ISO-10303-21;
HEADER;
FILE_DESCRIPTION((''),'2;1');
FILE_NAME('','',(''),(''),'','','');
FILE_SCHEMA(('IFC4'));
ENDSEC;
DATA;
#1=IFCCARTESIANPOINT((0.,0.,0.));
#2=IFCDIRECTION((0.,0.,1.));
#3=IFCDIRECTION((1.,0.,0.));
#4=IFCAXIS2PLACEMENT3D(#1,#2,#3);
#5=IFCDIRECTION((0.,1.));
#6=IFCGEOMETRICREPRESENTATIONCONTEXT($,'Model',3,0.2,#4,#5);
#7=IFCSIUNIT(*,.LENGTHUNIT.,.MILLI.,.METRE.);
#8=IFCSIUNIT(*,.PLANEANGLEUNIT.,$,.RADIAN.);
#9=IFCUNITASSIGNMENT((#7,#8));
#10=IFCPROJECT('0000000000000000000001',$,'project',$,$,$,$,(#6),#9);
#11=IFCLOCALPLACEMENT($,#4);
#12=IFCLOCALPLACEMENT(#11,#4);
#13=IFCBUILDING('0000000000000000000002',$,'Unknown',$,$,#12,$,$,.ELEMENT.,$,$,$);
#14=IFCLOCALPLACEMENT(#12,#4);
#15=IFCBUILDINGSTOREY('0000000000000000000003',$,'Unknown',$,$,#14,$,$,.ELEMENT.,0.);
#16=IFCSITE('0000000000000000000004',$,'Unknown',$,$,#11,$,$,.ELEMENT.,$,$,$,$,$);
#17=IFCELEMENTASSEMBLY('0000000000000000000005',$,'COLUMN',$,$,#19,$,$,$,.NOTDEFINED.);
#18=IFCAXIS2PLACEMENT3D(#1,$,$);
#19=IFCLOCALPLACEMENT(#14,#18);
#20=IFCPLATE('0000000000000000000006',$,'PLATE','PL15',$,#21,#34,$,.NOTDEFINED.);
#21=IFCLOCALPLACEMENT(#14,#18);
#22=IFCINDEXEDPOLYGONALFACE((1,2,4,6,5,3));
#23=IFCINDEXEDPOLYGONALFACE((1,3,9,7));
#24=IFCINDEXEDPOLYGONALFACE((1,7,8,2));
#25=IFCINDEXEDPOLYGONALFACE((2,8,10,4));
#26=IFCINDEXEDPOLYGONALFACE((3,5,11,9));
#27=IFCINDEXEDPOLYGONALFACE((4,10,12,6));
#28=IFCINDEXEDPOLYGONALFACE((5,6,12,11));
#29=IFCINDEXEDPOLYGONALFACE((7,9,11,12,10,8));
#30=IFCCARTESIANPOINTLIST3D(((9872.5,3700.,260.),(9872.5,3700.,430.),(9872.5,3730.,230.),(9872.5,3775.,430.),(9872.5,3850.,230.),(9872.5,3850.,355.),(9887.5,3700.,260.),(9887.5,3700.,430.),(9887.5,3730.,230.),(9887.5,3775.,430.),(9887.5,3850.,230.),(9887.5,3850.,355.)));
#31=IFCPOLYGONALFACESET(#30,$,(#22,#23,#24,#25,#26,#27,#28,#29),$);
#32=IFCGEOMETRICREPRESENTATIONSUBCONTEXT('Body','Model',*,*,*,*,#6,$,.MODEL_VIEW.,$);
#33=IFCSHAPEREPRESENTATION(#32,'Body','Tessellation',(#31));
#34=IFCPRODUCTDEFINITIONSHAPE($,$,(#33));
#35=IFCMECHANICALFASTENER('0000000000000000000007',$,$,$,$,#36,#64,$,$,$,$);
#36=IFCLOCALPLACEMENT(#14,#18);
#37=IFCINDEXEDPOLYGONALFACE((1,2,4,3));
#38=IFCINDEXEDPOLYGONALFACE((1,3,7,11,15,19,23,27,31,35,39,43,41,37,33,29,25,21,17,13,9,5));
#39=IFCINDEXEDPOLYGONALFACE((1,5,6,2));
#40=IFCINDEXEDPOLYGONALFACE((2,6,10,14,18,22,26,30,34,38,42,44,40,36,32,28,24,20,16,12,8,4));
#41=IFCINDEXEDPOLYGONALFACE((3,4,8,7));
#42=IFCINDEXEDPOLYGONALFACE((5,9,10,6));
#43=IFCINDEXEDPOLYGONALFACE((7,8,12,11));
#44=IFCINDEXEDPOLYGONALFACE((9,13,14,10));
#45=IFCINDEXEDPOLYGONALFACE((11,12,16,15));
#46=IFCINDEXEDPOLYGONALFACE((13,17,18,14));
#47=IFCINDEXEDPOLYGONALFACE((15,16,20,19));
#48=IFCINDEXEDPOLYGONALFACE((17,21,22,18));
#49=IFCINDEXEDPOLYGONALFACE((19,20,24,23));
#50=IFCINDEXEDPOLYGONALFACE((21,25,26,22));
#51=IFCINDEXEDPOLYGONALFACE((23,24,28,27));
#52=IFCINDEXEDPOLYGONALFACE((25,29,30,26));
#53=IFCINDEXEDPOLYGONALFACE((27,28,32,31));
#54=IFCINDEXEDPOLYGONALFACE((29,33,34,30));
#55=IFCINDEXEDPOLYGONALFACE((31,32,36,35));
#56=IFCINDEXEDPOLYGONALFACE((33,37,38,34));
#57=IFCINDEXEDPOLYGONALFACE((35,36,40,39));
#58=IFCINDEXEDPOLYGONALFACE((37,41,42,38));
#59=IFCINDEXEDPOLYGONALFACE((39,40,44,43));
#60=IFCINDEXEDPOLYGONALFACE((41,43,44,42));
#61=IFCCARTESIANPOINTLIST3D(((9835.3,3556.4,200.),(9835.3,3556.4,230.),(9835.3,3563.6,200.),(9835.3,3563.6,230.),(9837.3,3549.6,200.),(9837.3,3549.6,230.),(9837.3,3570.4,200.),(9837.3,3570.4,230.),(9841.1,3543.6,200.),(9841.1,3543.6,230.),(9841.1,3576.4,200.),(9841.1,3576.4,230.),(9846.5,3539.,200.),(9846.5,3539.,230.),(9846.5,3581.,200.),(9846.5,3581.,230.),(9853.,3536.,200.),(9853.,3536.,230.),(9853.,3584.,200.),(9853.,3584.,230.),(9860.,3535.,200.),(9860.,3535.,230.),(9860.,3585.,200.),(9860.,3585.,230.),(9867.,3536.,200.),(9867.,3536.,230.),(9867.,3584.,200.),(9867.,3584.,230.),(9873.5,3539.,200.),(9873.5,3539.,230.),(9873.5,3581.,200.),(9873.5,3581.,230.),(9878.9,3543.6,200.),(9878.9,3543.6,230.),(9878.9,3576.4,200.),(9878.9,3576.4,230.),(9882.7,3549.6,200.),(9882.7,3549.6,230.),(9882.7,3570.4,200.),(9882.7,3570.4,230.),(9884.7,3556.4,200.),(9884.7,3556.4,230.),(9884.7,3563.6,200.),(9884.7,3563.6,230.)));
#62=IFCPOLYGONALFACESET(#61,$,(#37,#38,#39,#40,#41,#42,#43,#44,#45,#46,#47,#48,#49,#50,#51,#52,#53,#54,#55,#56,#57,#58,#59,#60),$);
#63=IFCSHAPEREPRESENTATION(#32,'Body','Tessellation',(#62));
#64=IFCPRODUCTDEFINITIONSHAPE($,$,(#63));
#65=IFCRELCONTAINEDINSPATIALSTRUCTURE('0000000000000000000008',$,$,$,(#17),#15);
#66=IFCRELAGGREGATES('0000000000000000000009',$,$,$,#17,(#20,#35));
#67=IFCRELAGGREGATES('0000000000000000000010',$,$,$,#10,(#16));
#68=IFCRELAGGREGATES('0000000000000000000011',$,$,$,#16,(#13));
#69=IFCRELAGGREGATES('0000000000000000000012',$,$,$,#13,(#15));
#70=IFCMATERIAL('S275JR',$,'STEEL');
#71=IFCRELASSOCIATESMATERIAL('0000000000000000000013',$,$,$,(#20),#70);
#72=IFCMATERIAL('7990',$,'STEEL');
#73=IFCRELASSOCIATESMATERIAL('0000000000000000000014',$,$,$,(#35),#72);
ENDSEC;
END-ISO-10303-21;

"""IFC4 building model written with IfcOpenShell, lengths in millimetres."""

from ifc_helpers import new_model, si_unit, direction, frame, origin_with_axes, place, context, subcontext, project, spatial, line, arc, indexed_curve, outline, extrude, source, transform, mapped, material, element, aggregate, save


model = new_model("IFC4")

# Units and contexts
model_context = context("Model", 3, precision=0.2, world=origin_with_axes(), true_north=direction((0.0, 1.0)))
body_context = subcontext(model_context, "Body", "Model", "MODEL_VIEW")
ifc_project = project(units=[si_unit("LENGTHUNIT", "METRE", prefix="MILLI"), si_unit("PLANEANGLEUNIT", "RADIAN")], contexts=[model_context])

# Site, building, storey
site_placement = place(None, origin_with_axes())
site = spatial("IfcSite", under=ifc_project, at=site_placement, Name="Unknown", CompositionType="ELEMENT")
building_placement = place(site_placement, origin_with_axes())
building = spatial("IfcBuilding", under=site, at=building_placement, Name="Unknown", CompositionType="ELEMENT")
storey_placement = place(building_placement, origin_with_axes())
storey = spatial("IfcBuildingStorey", under=building, at=storey_placement, Name="Unknown", CompositionType="ELEMENT", Elevation=0.0)

# Shared definitions
ifc_material_1 = material(Name="S275JR", Category="STEEL")

# Element assembly, plate, mechanical fastener
assembly_1_placement = place(storey_placement, frame((9800.0, 3600.0, 200.0), z_axis=(-1.0, 0.0, 0.0), x_axis=(0.0, 0.0, 1.0)))
assembly_1 = element("IfcElementAssembly", 1, at=assembly_1_placement, inside=storey, Name="COLUMN", PredefinedType="NOTDEFINED")
plate_1_placement = place(assembly_1_placement, frame((60.0, 100.0, -80.0), z_axis=(0.0, -0.000002, -1.0), x_axis=(-0.707113, 0.707101, 0.0)))
plate_1 = element("IfcPlate", 2, at=plate_1_placement, material=ifc_material_1, Name="PLATE", Description="PL15", PredefinedType="NOTDEFINED", context=body_context, shape_type="SolidModel", body=[
    extrude(outline(indexed_curve([(0.0, 0.0), (42.4, 0.0), (127.3, 84.9), (38.9, 173.2), (-67.2, 173.2), (-120.2, 120.2)], segments=[line(1, 2, 3, 4, 5, 6, 1)])), frame((0.0, 0.0, 7.5), z_axis=(0.0, 0.0, 1.0), x_axis=(1.0, 0.0, 0.0)), (0.0, -0.000002, -1.0), 15.0),
])
ifc_material_2 = material(Name="7990", Category="STEEL")
shared_shape_1 = source(origin_with_axes(), body_context, "Body", "SweptSolid", [
    extrude(outline(indexed_curve([(25.0, 0.0), (0.0, 25.0), (-25.0, 0.0), (0.0, -25.0)], segments=[arc(1, 2, 3), arc(3, 4, 1)])), frame((0.0, 0.0, 0.0), z_axis=(0.0, -0.000002, -1.0), x_axis=(0.0, 1.0, 0.0)), (0.0, 0.0, 1.0), 30.0),
])
mechanical_fastener_1_placement = place(assembly_1_placement, frame((30.0, -40.0, -60.0), z_axis=(1.0, 0.0, 0.0), x_axis=(0.0, -0.000002, -1.0)))
mechanical_fastener_1 = element("IfcMechanicalFastener", 3, at=mechanical_fastener_1_placement, material=ifc_material_2, context=body_context, shape_type="MappedRepresentation", body=[
    mapped(shared_shape_1, transform((0.0, 0.0, 0.0))),
])

aggregate(assembly_1, [plate_1, mechanical_fastener_1])

save(model, "model.ifc")
